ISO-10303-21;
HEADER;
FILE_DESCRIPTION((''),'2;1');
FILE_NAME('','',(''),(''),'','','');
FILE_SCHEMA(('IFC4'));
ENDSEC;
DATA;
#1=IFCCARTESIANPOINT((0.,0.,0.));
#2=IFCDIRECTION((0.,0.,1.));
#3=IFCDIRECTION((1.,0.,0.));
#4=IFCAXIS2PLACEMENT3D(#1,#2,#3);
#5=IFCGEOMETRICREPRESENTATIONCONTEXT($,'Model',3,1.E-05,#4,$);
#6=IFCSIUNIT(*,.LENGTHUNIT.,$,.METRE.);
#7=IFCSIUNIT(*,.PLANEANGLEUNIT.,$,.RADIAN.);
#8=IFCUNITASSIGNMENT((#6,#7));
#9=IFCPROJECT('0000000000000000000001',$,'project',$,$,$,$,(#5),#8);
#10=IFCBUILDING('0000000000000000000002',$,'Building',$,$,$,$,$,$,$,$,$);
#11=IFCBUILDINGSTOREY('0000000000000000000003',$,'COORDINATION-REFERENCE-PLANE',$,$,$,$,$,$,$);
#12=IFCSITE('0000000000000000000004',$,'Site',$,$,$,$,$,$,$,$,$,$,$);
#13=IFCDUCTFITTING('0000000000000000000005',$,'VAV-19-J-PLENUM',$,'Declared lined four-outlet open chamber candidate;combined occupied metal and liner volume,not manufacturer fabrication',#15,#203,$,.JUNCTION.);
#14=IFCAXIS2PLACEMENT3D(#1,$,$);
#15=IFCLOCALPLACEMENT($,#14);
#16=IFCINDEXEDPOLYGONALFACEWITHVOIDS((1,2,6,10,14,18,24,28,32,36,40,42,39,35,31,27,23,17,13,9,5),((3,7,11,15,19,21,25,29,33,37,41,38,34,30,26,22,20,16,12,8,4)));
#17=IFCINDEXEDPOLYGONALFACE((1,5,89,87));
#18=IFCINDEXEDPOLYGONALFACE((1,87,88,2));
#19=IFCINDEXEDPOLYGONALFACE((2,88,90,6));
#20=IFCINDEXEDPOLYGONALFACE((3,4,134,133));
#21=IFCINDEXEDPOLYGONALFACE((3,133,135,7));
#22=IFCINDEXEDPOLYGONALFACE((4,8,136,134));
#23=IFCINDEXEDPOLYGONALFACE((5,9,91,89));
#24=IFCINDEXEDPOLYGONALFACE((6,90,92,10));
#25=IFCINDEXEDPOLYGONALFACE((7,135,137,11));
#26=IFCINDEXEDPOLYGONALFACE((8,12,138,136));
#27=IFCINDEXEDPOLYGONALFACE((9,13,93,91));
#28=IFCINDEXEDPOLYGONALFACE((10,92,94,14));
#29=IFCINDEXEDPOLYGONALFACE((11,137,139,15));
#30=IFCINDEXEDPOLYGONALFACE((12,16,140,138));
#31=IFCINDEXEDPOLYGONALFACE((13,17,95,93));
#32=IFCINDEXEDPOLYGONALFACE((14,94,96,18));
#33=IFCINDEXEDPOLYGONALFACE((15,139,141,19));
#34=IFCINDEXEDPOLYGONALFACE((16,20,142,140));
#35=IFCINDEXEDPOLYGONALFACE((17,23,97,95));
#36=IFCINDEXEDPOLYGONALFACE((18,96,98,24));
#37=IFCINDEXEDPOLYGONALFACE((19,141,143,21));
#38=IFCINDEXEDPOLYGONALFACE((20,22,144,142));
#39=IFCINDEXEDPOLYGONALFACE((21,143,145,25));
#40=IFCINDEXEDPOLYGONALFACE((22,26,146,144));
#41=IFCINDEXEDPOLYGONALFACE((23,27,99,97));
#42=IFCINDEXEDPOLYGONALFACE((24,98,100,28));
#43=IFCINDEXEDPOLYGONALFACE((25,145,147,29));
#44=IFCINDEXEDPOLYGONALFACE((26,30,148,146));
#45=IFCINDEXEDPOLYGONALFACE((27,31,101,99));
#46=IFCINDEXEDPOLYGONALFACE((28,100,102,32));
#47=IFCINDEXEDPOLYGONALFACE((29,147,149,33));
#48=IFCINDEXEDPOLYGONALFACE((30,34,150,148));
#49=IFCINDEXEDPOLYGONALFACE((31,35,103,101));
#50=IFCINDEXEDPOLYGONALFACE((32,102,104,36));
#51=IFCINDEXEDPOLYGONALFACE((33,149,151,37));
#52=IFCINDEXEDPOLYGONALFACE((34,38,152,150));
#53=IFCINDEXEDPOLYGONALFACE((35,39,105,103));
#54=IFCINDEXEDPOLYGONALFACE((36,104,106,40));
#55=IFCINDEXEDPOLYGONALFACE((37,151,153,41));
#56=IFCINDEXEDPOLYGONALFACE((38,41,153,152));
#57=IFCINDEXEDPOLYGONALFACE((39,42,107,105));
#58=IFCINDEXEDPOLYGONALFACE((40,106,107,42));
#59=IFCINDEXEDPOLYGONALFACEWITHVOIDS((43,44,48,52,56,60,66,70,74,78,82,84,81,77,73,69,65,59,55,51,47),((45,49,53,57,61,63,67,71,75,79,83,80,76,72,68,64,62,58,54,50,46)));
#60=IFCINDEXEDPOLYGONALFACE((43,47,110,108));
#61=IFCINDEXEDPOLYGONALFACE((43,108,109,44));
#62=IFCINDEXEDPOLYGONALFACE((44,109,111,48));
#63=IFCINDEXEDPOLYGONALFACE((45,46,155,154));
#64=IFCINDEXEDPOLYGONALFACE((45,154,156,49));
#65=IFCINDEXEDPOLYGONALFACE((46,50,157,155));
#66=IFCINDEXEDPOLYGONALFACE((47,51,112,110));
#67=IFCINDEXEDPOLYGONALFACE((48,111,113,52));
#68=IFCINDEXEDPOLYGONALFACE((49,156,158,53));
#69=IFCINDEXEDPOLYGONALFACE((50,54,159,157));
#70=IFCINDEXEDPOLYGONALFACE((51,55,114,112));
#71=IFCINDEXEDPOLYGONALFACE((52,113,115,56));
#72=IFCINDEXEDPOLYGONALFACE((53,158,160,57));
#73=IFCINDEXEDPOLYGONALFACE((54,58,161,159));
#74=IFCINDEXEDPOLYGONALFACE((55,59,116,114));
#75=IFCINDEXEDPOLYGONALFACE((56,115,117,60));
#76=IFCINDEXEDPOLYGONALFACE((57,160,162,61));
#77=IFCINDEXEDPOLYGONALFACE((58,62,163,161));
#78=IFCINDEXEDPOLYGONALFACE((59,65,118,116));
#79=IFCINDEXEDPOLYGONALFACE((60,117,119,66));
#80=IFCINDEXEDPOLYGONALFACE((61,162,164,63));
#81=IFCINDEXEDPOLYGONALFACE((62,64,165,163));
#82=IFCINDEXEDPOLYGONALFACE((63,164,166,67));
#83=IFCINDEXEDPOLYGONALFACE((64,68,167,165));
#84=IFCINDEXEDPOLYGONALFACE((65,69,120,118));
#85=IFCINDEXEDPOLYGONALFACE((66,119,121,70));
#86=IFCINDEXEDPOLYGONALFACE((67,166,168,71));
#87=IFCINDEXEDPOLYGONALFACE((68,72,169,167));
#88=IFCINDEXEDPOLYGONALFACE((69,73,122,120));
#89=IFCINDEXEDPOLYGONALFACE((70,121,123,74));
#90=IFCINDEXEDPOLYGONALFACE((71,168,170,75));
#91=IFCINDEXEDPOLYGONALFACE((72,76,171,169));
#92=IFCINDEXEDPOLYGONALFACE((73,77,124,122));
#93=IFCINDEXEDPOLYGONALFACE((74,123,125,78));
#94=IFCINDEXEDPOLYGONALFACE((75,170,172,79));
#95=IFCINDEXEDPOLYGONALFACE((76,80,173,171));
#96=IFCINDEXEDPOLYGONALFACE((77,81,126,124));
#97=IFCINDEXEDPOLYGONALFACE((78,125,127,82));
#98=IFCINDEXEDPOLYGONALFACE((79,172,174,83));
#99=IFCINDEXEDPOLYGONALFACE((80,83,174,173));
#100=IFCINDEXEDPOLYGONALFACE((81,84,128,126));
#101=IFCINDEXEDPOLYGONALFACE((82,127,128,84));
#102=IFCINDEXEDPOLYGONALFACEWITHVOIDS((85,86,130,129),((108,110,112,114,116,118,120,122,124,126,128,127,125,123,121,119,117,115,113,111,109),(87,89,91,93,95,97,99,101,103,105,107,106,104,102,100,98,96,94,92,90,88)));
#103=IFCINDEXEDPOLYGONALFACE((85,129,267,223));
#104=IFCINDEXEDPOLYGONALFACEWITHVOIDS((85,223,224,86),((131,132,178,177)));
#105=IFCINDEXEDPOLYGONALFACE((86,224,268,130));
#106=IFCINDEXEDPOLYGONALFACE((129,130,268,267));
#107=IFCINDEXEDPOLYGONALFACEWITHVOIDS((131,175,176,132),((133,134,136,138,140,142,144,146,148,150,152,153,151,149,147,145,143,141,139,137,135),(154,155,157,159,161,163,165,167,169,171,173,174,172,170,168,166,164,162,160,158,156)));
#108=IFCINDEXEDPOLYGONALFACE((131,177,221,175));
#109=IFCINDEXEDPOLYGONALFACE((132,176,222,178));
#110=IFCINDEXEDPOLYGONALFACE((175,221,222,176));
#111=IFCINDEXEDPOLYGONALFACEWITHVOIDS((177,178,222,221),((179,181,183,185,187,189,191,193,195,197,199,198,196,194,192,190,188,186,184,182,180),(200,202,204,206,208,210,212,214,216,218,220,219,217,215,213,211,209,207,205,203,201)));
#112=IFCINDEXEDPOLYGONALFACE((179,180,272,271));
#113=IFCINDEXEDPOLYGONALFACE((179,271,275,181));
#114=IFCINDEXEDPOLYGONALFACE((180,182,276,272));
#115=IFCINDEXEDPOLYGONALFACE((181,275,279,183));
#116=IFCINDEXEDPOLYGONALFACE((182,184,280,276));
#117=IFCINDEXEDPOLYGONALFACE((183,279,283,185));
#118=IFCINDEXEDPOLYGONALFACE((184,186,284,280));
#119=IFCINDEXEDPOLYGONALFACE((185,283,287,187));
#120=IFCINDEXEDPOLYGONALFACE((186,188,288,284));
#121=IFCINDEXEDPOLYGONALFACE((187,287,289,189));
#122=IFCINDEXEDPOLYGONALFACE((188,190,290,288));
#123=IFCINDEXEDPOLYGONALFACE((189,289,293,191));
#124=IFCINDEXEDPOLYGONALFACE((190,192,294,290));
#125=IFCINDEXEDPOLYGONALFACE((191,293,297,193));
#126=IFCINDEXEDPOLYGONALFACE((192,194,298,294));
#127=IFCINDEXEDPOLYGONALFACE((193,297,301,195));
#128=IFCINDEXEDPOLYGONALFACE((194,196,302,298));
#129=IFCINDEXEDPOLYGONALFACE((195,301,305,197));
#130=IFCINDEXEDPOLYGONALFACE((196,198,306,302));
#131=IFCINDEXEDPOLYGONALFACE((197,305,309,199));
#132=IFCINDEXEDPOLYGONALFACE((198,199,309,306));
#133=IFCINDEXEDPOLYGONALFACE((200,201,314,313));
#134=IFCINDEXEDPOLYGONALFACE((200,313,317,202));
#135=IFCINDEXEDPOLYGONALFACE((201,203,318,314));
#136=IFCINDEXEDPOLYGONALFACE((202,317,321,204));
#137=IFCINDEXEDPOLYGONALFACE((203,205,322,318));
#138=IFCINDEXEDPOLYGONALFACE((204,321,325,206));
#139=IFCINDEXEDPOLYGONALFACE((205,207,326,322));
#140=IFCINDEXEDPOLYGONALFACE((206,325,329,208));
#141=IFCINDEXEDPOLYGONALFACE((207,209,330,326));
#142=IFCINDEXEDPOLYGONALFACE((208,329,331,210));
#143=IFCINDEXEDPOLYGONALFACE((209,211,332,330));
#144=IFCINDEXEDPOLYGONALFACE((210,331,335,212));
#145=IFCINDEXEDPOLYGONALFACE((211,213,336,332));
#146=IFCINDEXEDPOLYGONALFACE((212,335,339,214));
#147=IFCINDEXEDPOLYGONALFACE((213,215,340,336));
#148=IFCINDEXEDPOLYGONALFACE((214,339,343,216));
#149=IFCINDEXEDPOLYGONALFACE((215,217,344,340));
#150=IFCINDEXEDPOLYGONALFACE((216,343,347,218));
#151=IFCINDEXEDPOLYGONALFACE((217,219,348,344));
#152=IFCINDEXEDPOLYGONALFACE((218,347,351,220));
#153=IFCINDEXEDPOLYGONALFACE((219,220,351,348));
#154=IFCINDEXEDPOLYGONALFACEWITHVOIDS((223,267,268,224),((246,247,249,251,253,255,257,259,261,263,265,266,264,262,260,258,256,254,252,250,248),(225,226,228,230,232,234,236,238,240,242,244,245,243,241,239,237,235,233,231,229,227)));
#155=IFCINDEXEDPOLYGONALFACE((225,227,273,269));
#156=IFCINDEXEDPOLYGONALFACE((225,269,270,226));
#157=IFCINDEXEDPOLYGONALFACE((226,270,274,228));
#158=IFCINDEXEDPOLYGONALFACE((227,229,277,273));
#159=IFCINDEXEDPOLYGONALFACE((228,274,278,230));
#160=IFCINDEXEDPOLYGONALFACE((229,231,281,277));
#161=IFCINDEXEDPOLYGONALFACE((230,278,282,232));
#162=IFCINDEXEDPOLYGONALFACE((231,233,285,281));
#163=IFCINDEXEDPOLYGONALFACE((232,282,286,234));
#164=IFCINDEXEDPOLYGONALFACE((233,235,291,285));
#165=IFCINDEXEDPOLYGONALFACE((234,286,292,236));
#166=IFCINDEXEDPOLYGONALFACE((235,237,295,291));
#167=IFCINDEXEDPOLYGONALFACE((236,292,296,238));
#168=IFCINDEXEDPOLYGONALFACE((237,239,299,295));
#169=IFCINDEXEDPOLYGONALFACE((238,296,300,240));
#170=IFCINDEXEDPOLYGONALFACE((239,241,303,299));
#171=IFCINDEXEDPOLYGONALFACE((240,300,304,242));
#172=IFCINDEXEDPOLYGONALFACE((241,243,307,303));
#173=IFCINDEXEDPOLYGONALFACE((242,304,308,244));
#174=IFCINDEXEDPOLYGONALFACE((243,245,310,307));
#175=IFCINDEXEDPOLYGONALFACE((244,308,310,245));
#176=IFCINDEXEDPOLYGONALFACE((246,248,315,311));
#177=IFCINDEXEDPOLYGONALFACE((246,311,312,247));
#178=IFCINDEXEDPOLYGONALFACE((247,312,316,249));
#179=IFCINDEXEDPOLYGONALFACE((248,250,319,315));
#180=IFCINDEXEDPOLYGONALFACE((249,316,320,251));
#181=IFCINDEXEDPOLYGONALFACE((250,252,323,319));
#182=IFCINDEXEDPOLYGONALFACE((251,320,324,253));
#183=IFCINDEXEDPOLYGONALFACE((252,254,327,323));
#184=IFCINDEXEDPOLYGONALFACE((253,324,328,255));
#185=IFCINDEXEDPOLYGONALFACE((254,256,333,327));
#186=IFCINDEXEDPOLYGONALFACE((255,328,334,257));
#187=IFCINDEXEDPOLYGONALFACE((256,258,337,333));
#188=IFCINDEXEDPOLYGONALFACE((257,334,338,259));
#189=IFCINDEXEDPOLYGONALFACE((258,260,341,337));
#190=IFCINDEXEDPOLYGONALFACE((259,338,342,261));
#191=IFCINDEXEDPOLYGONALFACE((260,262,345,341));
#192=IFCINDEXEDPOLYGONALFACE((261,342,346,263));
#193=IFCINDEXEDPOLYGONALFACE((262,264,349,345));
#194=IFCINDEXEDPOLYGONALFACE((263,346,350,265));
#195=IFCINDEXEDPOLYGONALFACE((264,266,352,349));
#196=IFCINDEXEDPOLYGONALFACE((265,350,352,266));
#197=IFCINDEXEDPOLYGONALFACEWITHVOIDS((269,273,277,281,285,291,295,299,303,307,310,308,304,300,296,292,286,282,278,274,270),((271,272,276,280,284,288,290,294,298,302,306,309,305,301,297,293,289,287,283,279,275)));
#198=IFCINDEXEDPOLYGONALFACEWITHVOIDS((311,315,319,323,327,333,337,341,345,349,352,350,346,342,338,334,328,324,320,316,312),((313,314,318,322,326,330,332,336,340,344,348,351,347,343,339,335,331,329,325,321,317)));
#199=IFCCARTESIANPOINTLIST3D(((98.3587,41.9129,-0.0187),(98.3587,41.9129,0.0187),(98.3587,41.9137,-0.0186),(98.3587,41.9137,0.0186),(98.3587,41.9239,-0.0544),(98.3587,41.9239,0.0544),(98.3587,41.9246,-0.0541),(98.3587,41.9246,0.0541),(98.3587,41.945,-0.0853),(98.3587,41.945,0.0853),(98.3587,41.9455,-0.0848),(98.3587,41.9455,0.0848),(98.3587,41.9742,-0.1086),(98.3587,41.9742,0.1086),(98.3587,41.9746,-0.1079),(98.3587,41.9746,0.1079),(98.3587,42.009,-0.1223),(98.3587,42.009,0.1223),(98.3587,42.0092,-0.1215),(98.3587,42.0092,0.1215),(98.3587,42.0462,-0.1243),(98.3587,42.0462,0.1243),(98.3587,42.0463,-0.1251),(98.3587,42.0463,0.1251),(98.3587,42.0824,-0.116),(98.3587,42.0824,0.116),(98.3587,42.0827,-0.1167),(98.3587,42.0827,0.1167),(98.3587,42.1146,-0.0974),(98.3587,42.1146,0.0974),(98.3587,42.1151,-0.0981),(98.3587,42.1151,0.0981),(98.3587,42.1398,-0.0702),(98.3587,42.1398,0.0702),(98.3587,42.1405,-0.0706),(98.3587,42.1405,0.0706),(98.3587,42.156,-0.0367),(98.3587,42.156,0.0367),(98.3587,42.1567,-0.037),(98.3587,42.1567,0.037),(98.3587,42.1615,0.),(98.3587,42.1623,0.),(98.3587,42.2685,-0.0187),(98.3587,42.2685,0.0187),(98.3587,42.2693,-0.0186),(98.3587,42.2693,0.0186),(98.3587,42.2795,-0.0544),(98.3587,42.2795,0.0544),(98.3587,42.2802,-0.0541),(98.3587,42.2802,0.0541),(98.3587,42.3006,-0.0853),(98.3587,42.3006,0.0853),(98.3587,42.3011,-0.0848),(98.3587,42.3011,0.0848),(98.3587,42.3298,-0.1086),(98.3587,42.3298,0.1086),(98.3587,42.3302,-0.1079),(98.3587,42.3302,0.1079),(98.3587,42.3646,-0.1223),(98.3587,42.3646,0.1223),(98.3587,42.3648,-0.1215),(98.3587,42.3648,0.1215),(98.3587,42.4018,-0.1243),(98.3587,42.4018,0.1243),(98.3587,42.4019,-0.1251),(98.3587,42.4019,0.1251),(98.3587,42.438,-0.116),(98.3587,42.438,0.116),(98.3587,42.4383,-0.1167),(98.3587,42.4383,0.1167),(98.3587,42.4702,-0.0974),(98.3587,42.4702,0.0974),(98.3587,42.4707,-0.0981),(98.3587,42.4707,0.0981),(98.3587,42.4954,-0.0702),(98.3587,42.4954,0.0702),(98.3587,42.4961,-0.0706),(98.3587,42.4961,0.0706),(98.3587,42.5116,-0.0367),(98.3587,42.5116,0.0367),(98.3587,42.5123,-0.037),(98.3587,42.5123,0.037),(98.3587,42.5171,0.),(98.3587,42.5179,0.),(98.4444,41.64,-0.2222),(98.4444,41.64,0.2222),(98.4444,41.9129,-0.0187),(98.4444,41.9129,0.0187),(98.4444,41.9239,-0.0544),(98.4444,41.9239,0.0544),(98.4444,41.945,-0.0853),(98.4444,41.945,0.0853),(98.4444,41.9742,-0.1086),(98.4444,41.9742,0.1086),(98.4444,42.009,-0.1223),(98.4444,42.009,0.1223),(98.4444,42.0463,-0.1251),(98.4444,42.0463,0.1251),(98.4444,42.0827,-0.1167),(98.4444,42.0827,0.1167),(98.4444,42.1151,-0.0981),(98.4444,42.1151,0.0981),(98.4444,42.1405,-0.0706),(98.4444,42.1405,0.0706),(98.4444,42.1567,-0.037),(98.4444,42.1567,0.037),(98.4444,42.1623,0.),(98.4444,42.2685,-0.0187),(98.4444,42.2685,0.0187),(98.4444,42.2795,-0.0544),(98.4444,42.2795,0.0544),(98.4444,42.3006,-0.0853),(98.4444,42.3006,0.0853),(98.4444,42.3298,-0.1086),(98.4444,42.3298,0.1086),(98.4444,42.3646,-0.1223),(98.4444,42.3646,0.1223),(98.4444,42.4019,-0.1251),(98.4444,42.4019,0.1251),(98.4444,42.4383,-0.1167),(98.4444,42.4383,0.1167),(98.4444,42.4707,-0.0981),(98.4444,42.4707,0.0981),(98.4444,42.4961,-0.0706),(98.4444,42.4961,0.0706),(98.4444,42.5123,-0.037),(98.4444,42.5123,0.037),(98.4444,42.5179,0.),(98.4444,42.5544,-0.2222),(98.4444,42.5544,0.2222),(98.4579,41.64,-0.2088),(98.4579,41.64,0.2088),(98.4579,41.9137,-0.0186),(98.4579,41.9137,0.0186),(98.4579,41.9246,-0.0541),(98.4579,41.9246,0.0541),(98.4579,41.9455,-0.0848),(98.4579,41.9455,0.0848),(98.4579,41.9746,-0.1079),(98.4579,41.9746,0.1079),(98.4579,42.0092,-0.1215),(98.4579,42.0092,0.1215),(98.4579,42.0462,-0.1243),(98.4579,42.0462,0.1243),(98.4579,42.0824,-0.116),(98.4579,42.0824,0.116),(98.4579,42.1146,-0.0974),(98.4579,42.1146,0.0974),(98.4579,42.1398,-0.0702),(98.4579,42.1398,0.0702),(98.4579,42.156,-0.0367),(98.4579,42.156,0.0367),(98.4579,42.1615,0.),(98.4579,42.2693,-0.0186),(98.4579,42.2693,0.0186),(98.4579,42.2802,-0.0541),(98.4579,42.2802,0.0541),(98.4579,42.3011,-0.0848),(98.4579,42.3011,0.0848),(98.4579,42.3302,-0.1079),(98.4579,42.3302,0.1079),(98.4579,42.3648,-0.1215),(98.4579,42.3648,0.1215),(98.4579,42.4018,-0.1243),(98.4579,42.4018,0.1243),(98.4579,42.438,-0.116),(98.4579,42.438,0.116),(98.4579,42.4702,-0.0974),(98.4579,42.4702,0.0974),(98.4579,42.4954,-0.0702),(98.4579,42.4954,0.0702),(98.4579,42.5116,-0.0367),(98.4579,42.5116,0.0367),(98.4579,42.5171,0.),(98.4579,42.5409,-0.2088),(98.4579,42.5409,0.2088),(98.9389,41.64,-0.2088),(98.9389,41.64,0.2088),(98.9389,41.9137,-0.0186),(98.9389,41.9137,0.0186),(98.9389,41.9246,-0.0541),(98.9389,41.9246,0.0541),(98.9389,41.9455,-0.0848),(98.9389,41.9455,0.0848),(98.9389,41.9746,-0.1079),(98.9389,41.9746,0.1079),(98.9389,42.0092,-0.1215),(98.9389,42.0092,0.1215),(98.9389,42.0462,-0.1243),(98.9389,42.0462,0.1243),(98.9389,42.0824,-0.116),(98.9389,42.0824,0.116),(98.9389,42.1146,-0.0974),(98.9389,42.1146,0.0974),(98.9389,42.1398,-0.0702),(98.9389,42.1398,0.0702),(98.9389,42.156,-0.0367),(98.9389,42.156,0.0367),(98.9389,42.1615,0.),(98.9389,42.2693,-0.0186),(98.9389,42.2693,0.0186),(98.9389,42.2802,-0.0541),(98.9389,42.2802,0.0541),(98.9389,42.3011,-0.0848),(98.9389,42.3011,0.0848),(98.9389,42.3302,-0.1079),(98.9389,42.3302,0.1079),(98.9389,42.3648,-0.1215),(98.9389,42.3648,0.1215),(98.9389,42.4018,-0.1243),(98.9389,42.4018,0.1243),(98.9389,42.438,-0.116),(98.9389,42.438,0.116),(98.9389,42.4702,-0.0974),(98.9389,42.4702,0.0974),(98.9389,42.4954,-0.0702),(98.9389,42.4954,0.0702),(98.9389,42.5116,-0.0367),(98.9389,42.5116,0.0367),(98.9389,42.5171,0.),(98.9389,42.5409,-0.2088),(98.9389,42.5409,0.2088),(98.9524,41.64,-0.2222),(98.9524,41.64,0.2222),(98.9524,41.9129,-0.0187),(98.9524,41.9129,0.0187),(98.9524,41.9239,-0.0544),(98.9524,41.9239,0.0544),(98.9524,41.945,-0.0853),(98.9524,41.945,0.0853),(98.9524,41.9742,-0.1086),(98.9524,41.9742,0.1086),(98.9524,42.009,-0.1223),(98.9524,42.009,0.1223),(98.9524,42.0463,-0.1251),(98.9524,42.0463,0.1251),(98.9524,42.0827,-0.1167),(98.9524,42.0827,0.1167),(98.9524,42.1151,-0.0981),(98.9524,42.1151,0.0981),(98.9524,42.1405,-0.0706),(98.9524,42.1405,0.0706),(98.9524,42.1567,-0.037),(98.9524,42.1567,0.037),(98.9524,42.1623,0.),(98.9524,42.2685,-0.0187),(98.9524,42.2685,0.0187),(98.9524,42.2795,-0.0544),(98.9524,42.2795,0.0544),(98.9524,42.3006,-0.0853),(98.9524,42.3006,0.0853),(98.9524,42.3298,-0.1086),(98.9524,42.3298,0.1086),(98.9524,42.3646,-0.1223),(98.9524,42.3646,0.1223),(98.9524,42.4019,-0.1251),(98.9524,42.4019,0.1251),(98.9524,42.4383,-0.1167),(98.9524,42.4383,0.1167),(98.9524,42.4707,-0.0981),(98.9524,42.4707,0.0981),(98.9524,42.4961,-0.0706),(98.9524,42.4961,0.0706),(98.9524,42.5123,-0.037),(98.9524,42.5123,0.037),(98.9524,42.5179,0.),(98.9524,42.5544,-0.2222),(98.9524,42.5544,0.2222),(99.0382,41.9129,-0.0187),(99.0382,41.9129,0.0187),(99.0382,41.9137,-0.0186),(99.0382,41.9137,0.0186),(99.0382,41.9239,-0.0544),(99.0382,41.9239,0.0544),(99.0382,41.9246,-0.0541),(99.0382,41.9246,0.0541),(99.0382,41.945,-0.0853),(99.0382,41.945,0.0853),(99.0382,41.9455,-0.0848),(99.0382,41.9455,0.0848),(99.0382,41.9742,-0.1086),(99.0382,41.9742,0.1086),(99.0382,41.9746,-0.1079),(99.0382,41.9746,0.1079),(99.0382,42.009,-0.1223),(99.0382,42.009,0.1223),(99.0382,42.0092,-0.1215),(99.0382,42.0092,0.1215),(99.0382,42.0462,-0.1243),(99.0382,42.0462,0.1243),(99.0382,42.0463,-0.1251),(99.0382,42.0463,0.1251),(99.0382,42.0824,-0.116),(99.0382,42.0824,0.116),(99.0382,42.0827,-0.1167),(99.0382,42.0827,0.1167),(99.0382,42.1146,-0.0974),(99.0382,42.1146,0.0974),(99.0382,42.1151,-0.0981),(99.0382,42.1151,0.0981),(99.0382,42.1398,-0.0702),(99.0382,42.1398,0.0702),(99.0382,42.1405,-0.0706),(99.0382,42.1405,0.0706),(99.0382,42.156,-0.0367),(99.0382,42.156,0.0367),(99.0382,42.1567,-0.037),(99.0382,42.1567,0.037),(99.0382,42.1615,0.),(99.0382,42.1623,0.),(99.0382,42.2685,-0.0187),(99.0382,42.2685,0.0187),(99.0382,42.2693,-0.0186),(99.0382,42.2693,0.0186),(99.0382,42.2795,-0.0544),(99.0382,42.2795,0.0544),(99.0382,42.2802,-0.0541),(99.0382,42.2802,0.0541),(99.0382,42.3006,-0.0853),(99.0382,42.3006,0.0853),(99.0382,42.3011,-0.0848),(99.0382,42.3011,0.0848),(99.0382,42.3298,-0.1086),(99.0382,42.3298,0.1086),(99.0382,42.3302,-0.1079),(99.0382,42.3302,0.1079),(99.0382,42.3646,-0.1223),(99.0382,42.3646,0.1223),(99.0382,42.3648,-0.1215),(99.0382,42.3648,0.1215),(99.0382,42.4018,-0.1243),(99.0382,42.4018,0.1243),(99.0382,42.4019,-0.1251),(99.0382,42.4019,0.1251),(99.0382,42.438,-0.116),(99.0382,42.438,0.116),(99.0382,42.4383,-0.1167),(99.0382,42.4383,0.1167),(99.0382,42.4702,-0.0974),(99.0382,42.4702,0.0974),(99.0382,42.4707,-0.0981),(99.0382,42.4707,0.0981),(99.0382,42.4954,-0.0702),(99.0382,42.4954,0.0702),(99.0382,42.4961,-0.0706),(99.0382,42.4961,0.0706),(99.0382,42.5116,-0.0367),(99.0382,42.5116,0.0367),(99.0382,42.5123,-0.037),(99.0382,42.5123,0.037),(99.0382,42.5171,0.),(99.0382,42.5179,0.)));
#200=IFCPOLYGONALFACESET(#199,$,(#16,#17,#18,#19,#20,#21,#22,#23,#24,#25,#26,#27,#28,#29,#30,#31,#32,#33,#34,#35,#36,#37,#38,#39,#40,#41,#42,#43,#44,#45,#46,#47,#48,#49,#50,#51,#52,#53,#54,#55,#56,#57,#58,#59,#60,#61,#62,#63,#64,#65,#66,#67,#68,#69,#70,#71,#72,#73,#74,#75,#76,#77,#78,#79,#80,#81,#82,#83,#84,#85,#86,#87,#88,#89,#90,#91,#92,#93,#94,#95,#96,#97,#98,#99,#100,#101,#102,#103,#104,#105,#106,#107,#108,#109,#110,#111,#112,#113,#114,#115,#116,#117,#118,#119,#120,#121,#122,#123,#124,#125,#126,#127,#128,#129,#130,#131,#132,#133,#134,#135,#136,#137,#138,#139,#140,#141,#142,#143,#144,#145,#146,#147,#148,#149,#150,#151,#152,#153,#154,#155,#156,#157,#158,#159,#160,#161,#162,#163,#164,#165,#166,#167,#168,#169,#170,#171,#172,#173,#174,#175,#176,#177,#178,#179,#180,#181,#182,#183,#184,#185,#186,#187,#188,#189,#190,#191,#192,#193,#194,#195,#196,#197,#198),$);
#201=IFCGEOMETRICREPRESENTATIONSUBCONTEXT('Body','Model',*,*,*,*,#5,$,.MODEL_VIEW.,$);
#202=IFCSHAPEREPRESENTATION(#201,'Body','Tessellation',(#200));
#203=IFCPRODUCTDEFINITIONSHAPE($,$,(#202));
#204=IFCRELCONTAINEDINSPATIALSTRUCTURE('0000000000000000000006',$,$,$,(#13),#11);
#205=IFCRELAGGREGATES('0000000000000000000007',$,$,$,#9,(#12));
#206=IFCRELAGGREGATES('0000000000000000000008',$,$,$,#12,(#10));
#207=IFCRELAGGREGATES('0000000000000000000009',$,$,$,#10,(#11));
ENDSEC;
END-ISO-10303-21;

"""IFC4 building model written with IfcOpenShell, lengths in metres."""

from ifc_helpers import new_model, si_unit, frame, origin_with_axes, place, context, subcontext, project, spatial, rectangle, circle, extrude, boolean, element, save


model = new_model("IFC4")

# Units and contexts
model_context = context("Model", 3, precision=1e-05, world=origin_with_axes())
body_context_1 = subcontext(model_context, "Body", "Model", "MODEL_VIEW")
ifc_project = project(units=[si_unit("LENGTHUNIT", "METRE"), si_unit("PLANEANGLEUNIT", "RADIAN")], contexts=[model_context])

# Site, building, storey
site = spatial("IfcSite", under=ifc_project, Name="Site")
building = spatial("IfcBuilding", under=site, Name="Building")
storey = spatial("IfcBuildingStorey", under=building, Name="COORDINATION-REFERENCE-PLANE")

# Duct fitting
duct_fitting_1_placement = place(None, frame((98.4444, 41.64, -0.2223), z_axis=(0.0, 0.0, 1.0), x_axis=(1.0, 0.0, 0.0)))
solid_1 = boolean("UNION", boolean("UNION", boolean("UNION", boolean("UNION", extrude(rectangle(XDim=0.481, YDim=0.4175), frame((0.254, -0.01, 0.2223), z_axis=(0.0, 1.0, 0.0), x_axis=(-1.0, 0.0, 0.0)), (0.0, 0.0, 1.0), 0.9109), extrude(circle(Radius=0.1246), frame((0.4845, 0.3969, 0.2223), z_axis=(1.0, 0.0, 0.0), x_axis=(0.0, 1.0, 0.0)), (0.0, 0.0, 1.0), 0.1192)), extrude(circle(Radius=0.1246), frame((0.0235, 0.3969, 0.2223), z_axis=(-1.0, 0.0, 0.0), x_axis=(0.0, 1.0, 0.0)), (0.0, 0.0, 1.0), 0.1192)), extrude(circle(Radius=0.1246), frame((0.4845, 0.7525, 0.2223), z_axis=(1.0, 0.0, 0.0), x_axis=(0.0, 1.0, 0.0)), (0.0, 0.0, 1.0), 0.1192)), extrude(circle(Radius=0.1246), frame((0.0235, 0.7525, 0.2223), z_axis=(-1.0, 0.0, 0.0), x_axis=(0.0, 1.0, 0.0)), (0.0, 0.0, 1.0), 0.1192))
element("IfcDuctFitting", 1, at=duct_fitting_1_placement, inside=storey, Name="VAV-19-J-PLENUM", ObjectType="Declared lined four-outlet open chamber candidate;combined occupied metal and liner volume,not manufacturer fabrication", PredefinedType="JUNCTION", context=body_context_1, shape_type="CSG", body=[
    boolean("DIFFERENCE", boolean("UNION", boolean("UNION", boolean("UNION", boolean("UNION", extrude(rectangle(XDim=0.508, YDim=0.4445), frame((0.254, 0.0, 0.2223), z_axis=(0.0, 1.0, 0.0), x_axis=(-1.0, 0.0, 0.0)), (0.0, 0.0, 1.0), 0.9144), extrude(circle(Radius=0.1254), frame((0.4845, 0.3969, 0.2223), z_axis=(1.0, 0.0, 0.0), x_axis=(0.0, 1.0, 0.0)), (0.0, 0.0, 1.0), 0.1092)), extrude(circle(Radius=0.1254), frame((0.0235, 0.3969, 0.2223), z_axis=(-1.0, 0.0, 0.0), x_axis=(0.0, 1.0, 0.0)), (0.0, 0.0, 1.0), 0.1092)), extrude(circle(Radius=0.1254), frame((0.4845, 0.7525, 0.2223), z_axis=(1.0, 0.0, 0.0), x_axis=(0.0, 1.0, 0.0)), (0.0, 0.0, 1.0), 0.1092)), extrude(circle(Radius=0.1254), frame((0.0235, 0.7525, 0.2223), z_axis=(-1.0, 0.0, 0.0), x_axis=(0.0, 1.0, 0.0)), (0.0, 0.0, 1.0), 0.1092)), solid_1),
])

save(model, "model.ifc")
